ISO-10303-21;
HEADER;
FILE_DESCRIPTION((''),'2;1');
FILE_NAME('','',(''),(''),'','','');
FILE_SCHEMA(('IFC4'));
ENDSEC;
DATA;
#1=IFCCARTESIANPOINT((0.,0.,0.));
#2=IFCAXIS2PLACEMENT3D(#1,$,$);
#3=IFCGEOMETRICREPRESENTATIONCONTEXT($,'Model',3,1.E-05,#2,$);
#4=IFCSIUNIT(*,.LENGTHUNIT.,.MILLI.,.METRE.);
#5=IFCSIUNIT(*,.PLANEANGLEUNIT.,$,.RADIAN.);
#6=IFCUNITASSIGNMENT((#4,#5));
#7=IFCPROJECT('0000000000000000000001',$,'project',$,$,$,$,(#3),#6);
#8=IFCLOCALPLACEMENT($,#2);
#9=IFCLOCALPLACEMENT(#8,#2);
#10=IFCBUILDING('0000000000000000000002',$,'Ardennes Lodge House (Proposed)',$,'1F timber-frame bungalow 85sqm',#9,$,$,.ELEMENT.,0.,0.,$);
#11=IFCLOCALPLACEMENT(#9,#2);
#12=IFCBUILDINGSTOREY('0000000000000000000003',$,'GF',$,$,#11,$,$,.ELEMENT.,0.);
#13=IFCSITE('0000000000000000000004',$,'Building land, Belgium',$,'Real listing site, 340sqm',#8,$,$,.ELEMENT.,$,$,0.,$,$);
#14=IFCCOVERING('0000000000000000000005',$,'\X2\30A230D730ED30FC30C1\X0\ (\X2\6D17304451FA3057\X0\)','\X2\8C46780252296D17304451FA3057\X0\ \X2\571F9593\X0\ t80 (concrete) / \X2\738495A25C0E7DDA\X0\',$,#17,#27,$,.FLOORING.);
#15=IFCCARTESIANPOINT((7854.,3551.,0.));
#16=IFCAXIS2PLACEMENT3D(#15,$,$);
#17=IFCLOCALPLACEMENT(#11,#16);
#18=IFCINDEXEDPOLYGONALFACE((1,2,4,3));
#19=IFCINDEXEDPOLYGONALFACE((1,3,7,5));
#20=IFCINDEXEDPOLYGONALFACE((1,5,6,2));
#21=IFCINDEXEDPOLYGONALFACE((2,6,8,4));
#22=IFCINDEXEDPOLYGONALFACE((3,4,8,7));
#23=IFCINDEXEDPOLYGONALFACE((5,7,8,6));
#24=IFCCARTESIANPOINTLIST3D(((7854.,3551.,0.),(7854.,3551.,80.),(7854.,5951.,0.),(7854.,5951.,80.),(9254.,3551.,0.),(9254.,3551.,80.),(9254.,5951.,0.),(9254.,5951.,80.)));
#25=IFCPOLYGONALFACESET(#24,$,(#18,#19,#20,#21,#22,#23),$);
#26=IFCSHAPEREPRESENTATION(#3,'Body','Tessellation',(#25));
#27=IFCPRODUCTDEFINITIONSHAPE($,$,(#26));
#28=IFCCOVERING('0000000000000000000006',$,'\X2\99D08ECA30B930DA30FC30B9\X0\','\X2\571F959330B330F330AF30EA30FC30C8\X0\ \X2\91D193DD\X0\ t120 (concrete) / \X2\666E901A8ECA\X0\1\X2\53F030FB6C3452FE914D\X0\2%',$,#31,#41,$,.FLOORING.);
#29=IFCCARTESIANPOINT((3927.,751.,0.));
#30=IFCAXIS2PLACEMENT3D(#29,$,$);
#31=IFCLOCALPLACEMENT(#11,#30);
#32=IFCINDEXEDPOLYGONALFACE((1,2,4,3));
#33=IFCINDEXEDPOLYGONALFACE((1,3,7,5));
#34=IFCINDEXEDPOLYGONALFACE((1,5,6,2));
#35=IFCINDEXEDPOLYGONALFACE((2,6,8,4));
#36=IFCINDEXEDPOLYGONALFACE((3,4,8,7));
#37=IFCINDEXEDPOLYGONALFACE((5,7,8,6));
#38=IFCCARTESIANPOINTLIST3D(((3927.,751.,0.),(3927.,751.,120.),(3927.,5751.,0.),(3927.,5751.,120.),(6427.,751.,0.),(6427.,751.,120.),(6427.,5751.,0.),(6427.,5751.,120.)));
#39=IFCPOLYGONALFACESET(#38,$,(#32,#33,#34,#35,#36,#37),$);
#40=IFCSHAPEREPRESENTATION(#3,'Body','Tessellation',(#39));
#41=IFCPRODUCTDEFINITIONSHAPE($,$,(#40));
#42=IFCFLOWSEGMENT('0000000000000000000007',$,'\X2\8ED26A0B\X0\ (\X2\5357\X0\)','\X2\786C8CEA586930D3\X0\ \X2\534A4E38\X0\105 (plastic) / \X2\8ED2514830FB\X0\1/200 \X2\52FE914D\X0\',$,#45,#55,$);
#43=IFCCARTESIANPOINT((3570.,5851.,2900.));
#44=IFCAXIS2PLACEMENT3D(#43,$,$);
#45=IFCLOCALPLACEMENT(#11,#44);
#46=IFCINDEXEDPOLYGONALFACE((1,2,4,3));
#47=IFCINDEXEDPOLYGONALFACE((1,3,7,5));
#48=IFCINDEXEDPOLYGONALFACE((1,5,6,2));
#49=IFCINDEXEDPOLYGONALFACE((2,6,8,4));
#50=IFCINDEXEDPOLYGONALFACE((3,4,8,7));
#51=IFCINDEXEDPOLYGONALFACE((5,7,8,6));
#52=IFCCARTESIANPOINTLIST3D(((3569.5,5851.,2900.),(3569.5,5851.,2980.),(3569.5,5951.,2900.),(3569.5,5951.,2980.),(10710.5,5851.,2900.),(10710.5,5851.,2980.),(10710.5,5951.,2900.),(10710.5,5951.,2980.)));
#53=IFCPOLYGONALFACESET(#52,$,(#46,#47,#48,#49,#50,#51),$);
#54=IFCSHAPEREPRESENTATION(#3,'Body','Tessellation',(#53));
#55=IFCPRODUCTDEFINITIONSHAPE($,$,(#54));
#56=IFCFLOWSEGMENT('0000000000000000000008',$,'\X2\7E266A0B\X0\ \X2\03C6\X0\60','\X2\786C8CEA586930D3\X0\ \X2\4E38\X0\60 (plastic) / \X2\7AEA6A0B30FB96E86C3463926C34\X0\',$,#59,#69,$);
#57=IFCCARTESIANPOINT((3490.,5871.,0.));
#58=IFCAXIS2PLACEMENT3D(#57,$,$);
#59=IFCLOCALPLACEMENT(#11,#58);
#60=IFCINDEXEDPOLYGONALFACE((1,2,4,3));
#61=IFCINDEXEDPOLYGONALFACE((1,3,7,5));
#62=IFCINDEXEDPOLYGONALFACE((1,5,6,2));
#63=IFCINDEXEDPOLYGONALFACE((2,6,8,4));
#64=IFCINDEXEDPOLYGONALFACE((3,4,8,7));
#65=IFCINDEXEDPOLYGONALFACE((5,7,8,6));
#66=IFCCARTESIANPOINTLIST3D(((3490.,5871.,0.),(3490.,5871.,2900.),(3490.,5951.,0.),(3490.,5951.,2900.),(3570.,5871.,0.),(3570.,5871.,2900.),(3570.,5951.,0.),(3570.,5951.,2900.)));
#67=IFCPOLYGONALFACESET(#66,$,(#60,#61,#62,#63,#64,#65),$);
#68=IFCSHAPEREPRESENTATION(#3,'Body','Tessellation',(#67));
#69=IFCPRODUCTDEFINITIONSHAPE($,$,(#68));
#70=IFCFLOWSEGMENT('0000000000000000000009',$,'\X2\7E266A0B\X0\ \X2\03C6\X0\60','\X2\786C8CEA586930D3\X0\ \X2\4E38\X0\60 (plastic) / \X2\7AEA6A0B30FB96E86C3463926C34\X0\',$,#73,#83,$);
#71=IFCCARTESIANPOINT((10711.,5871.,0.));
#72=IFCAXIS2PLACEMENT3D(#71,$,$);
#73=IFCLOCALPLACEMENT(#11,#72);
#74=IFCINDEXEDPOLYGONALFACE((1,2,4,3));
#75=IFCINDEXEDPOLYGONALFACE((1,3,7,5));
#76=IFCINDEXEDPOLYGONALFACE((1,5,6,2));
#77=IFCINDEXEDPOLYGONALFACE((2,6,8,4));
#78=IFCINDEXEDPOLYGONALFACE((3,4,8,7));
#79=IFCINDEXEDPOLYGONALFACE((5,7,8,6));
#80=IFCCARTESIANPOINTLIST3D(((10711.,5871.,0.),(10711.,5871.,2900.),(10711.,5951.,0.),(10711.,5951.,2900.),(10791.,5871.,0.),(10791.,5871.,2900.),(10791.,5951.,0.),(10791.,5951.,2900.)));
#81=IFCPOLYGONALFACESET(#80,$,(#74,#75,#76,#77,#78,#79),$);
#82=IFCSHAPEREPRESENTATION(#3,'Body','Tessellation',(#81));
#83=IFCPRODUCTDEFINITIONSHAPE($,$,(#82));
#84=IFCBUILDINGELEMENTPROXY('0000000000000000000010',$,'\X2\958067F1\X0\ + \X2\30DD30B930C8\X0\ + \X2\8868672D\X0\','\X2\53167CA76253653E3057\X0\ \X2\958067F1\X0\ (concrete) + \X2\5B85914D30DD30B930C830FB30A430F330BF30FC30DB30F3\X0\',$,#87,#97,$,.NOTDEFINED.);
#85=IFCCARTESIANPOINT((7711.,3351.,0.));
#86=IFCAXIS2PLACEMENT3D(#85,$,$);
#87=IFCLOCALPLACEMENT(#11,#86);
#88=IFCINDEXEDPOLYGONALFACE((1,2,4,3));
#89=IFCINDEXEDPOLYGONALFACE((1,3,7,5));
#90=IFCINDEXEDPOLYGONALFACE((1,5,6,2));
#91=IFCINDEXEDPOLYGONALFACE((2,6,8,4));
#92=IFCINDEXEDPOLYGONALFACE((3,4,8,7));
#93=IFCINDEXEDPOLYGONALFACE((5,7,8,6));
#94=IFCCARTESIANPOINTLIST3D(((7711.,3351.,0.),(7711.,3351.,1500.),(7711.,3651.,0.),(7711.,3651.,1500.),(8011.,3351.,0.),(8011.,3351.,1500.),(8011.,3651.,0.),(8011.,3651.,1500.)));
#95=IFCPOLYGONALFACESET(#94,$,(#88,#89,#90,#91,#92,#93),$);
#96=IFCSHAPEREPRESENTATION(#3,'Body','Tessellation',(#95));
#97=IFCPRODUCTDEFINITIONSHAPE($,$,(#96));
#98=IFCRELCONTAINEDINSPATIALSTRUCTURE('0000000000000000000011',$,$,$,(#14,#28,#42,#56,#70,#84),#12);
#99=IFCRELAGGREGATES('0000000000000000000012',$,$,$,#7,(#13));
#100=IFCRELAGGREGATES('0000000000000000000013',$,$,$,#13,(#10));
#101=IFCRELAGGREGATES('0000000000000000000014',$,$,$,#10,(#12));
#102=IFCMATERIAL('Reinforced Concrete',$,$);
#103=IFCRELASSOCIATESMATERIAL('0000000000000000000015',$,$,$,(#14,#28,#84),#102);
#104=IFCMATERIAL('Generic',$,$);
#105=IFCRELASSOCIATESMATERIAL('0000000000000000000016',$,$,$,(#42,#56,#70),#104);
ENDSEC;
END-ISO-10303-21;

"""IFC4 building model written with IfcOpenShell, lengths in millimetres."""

from ifc_helpers import new_model, si_unit, frame, frame_2d, origin, place, context, project, spatial, rectangle, extrude, material, element, save


model = new_model("IFC4")

# Units and contexts
model_context = context("Model", 3, precision=1e-05, world=origin())
ifc_project = project(units=[si_unit("LENGTHUNIT", "METRE", prefix="MILLI"), si_unit("PLANEANGLEUNIT", "RADIAN")], contexts=[model_context])

# Site, building, storey
site_placement = place(None, origin())
site = spatial("IfcSite", under=ifc_project, at=site_placement, Name="Building land, Belgium", ObjectType="Real listing site, 340sqm", CompositionType="ELEMENT", RefElevation=0.0)
building_placement = place(site_placement, origin())
building = spatial("IfcBuilding", under=site, at=building_placement, Name="Ardennes Lodge House (Proposed)", ObjectType="1F timber-frame bungalow 85sqm", CompositionType="ELEMENT", ElevationOfRefHeight=0.0, ElevationOfTerrain=0.0)
storey_placement = place(building_placement, origin())
storey = spatial("IfcBuildingStorey", under=building, at=storey_placement, Name="GF", CompositionType="ELEMENT", Elevation=0.0)

# Shared definitions
ifc_material_1 = material(Name="Reinforced Concrete")

# Coverings
covering_1_placement = place(storey_placement, frame((7854.0, 3551.0, 0.0)))
element("IfcCovering", 1, at=covering_1_placement, inside=storey, material=ifc_material_1, Name="アプローチ (洗い出し)", Description="豆砂利洗い出し 土間 t80 (concrete) / 玄関導線", PredefinedType="FLOORING", context=model_context, shape_type="SweptSolid", body=[
    extrude(rectangle(XDim=1400.0, YDim=2400.0, at=frame_2d((700.0, 1200.0))), frame((7854.0, 3551.0, 0.0)), (0.0, 0.0, 1.0), 80.0),
])
covering_2_placement = place(storey_placement, frame((3927.0, 751.0, 0.0)))
element("IfcCovering", 2, at=covering_2_placement, inside=storey, material=ifc_material_1, Name="駐車スペース", Description="土間コンクリート 金鏝 t120 (concrete) / 普通車1台・水勾配2%", PredefinedType="FLOORING", context=model_context, shape_type="SweptSolid", body=[
    extrude(rectangle(XDim=2500.0, YDim=5000.0, at=frame_2d((1250.0, 2500.0))), frame((3927.0, 751.0, 0.0)), (0.0, 0.0, 1.0), 120.0),
])

# Flow segments
ifc_material_2 = material(Name="Generic")
flow_segment_1_placement = place(storey_placement, frame((3570.0, 5851.0, 2900.0)))
element("IfcFlowSegment", 3, at=flow_segment_1_placement, inside=storey, material=ifc_material_2, Name="軒樋 (南)", Description="硬質塩ビ 半丸105 (plastic) / 軒先・1/200 勾配", context=model_context, shape_type="SweptSolid", body=[
    extrude(rectangle(XDim=7141.0, YDim=100.0, at=frame_2d((3570.0, 50.0))), frame((3570.0, 5851.0, 2900.0)), (0.0, 0.0, 1.0), 80.0),
])
flow_segment_2_placement = place(storey_placement, frame((3490.0, 5871.0, 0.0)))
element("IfcFlowSegment", 4, at=flow_segment_2_placement, inside=storey, material=ifc_material_2, Name="縦樋 φ60", Description="硬質塩ビ 丸60 (plastic) / 竪樋・雨水排水", context=model_context, shape_type="SweptSolid", body=[
    extrude(rectangle(XDim=80.0, YDim=80.0, at=frame_2d((40.0, 40.0))), frame((3490.0, 5871.0, 0.0)), (0.0, 0.0, 1.0), 2900.0),
])
flow_segment_3_placement = place(storey_placement, frame((10711.0, 5871.0, 0.0)))
element("IfcFlowSegment", 5, at=flow_segment_3_placement, inside=storey, material=ifc_material_2, Name="縦樋 φ60", Description="硬質塩ビ 丸60 (plastic) / 竪樋・雨水排水", context=model_context, shape_type="SweptSolid", body=[
    extrude(rectangle(XDim=80.0, YDim=80.0, at=frame_2d((40.0, 40.0))), frame((10711.0, 5871.0, 0.0)), (0.0, 0.0, 1.0), 2900.0),
])

# Building element proxy
proxy_placement = place(storey_placement, frame((7711.0, 3351.0, 0.0)))
element("IfcBuildingElementProxy", 6, at=proxy_placement, inside=storey, material=ifc_material_1, Name="門柱 + ポスト + 表札", Description="化粧打放し 門柱 (concrete) + 宅配ポスト・インターホン", PredefinedType="NOTDEFINED", context=model_context, shape_type="SweptSolid", body=[
    extrude(rectangle(XDim=300.0, YDim=300.0, at=frame_2d((150.0, 150.0))), frame((7711.0, 3351.0, 0.0)), (0.0, 0.0, 1.0), 1500.0),
])

save(model, "model.ifc")
